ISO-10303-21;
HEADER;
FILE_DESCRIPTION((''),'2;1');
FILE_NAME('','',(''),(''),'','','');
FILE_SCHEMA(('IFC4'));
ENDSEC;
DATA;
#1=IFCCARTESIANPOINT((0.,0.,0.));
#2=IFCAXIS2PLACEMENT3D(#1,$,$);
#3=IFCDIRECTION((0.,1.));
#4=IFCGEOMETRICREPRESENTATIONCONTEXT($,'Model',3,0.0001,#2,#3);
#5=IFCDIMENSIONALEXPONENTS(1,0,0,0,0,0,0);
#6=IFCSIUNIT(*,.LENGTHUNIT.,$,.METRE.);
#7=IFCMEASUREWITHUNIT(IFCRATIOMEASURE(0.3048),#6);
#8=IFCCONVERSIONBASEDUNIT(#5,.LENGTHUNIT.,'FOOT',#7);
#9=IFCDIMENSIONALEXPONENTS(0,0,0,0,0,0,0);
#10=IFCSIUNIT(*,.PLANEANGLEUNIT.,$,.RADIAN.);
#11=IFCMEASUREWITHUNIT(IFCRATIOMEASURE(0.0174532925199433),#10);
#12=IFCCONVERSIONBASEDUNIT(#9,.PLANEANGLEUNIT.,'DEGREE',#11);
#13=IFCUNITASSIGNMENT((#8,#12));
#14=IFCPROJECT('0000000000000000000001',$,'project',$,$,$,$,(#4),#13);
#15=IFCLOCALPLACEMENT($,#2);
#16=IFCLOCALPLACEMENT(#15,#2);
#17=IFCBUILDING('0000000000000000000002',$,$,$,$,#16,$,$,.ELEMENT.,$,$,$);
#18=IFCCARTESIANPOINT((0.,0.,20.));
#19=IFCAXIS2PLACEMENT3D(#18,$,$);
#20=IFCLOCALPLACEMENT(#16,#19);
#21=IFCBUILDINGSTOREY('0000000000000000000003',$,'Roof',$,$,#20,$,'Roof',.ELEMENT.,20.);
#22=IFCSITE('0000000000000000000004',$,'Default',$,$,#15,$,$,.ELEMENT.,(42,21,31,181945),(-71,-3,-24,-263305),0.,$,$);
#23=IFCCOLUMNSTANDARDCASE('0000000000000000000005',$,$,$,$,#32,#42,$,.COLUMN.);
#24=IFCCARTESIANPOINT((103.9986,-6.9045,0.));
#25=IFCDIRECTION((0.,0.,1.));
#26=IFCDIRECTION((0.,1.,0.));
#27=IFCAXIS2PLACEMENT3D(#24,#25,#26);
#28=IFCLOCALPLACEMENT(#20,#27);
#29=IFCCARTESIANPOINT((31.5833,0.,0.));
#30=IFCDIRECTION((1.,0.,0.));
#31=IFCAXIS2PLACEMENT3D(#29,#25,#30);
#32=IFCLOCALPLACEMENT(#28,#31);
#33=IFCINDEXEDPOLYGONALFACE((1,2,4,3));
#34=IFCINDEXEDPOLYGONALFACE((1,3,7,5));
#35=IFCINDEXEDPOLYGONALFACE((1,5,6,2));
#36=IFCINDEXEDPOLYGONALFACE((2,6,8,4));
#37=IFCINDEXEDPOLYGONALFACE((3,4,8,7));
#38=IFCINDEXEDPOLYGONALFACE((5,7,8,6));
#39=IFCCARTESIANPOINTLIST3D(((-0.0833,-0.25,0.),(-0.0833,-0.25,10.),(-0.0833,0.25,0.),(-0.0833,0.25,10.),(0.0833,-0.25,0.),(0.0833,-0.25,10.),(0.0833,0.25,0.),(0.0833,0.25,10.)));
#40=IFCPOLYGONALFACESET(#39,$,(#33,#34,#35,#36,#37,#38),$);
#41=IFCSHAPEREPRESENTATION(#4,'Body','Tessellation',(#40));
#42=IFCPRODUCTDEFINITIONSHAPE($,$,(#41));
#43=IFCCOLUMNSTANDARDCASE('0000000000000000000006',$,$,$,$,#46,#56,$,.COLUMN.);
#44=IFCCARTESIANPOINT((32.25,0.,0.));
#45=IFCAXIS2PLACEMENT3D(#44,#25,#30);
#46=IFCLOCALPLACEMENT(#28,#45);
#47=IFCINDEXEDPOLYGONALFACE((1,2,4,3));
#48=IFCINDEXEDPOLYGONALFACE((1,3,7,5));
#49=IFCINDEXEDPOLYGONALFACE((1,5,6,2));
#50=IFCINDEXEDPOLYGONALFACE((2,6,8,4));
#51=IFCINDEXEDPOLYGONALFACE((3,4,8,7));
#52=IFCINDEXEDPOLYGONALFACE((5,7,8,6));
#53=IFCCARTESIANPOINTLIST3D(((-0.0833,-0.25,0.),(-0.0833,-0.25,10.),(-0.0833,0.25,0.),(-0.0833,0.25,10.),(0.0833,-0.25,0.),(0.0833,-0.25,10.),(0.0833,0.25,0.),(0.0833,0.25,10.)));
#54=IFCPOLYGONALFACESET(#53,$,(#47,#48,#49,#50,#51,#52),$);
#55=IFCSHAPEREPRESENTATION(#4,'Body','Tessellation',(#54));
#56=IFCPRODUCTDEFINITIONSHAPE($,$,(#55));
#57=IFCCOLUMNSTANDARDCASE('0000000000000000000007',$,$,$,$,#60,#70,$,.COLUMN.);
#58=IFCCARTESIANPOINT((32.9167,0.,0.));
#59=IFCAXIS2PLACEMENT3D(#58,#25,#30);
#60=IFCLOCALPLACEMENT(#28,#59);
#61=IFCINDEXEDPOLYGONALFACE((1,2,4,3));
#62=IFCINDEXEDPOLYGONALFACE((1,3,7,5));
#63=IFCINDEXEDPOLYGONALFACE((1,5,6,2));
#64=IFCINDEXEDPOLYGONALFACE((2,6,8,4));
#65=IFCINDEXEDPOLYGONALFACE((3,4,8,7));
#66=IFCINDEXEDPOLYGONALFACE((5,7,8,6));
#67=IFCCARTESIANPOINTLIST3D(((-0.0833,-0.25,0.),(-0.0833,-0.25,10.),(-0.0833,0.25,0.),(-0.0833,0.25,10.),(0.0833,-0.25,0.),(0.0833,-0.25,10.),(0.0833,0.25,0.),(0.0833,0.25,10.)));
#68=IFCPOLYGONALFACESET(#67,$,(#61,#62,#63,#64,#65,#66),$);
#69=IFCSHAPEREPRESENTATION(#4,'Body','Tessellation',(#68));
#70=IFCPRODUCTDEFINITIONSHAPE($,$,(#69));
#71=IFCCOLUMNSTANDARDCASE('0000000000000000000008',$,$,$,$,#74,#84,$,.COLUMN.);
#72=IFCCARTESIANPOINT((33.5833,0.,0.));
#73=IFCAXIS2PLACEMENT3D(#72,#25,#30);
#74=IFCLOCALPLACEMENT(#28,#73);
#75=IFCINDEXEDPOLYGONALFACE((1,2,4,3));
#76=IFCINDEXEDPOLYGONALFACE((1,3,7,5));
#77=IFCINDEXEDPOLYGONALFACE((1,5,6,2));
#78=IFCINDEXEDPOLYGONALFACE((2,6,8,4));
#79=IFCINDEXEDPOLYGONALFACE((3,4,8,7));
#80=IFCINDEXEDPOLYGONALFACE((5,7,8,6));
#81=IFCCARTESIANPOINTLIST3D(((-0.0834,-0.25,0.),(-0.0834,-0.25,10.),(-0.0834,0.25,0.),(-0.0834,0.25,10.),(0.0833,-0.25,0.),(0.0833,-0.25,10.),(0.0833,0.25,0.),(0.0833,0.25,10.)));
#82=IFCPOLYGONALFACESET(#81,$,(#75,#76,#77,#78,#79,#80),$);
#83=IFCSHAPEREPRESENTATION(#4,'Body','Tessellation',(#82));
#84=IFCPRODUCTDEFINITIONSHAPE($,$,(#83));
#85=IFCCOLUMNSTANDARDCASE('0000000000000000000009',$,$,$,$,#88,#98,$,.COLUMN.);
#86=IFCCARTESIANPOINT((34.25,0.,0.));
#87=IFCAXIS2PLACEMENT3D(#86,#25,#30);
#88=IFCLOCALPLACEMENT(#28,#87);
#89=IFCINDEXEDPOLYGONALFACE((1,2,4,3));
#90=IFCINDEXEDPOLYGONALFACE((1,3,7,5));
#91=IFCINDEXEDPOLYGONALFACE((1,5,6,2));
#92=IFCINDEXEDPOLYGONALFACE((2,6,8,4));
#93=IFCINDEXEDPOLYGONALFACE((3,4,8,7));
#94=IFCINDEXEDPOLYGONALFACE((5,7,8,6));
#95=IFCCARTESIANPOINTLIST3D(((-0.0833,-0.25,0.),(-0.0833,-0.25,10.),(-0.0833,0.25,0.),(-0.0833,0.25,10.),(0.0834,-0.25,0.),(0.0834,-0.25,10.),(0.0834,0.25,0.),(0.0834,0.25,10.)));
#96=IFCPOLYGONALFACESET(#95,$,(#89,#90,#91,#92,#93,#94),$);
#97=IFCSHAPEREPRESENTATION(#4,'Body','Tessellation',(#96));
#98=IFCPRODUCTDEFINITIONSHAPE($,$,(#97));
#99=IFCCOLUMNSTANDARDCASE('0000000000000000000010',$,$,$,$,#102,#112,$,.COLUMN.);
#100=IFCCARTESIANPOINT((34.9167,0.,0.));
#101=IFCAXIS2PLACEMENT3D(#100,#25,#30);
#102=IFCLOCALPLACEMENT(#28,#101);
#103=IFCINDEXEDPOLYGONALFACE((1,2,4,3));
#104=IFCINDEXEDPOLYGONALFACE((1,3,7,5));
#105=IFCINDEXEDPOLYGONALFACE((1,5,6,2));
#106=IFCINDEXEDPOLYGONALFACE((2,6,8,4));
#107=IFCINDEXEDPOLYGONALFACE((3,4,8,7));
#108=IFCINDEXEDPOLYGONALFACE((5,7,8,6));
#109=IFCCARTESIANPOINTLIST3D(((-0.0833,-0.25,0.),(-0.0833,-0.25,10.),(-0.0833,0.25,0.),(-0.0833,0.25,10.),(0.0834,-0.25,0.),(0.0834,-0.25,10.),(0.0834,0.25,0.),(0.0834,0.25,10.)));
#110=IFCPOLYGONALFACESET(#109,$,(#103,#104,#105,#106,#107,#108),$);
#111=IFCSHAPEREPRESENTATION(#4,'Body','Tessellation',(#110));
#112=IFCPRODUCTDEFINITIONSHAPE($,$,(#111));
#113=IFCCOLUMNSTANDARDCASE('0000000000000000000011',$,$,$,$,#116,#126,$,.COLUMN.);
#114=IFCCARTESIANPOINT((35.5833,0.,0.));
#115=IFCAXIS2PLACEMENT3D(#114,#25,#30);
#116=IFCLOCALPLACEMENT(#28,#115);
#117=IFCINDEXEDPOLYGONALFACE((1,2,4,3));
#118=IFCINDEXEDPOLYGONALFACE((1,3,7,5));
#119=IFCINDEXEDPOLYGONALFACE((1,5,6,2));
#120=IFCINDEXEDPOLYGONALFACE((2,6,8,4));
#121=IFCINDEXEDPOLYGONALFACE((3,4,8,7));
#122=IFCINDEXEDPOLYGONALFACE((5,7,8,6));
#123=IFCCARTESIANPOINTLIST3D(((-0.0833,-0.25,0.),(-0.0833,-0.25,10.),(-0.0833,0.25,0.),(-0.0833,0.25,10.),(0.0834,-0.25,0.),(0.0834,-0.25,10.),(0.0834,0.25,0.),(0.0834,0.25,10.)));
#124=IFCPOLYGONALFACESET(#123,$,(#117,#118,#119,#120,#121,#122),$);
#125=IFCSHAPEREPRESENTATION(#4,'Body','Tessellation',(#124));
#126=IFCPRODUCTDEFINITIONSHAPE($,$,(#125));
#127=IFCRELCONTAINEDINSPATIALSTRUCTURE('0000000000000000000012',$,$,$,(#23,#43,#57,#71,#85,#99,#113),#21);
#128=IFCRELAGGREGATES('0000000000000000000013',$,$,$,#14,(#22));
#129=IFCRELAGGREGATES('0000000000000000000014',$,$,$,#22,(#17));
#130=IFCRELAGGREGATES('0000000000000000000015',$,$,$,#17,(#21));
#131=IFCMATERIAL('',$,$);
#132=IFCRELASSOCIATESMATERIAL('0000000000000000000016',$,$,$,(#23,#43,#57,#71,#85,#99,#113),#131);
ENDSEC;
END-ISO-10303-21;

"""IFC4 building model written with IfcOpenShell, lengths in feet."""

from ifc_helpers import new_model, entity, si_unit, converted_unit, direction, frame, origin, place, context, project, spatial, rectangle, extrude, material, element, save


model = new_model("IFC4")

# Units and contexts
model_context = context("Model", 3, precision=0.0001, world=origin(), true_north=direction((0.0, 1.0)))
ifc_project = project(units=[converted_unit("LENGTHUNIT", "FOOT", entity("IfcRatioMeasure", 0.3048), si_unit("LENGTHUNIT", "METRE"), dimensions=[1, 0, 0, 0, 0, 0, 0]), converted_unit("PLANEANGLEUNIT", "DEGREE", entity("IfcRatioMeasure", 0.0174532925199433), si_unit("PLANEANGLEUNIT", "RADIAN"), dimensions=[0, 0, 0, 0, 0, 0, 0])], contexts=[model_context])

# Site, building, storey
site_placement = place(None, origin())
site = spatial("IfcSite", under=ifc_project, at=site_placement, Name="Default", CompositionType="ELEMENT", RefLatitude=(42, 21, 31, 181945), RefLongitude=(-71, -3, -24, -263305), RefElevation=0.0)
building_placement = place(site_placement, origin())
building = spatial("IfcBuilding", under=site, at=building_placement, CompositionType="ELEMENT")
storey_placement = place(building_placement, frame((0.0, 0.0, 20.0)))
storey = spatial("IfcBuildingStorey", under=building, at=storey_placement, Name="Roof", LongName="Roof", CompositionType="ELEMENT", Elevation=20.0)

# Columns
ifc_material_1 = material(Name="")
placement_1 = place(storey_placement, frame((103.9986, -6.9045, 0.0), z_axis=(0.0, 0.0, 1.0), x_axis=(0.0, 1.0, 0.0)))
for number, where, z_axis, x_axis in (
    (1, (31.5833, 0.0, 0.0), (0.0, 0.0, 1.0), (1.0, 0.0, 0.0)),
    (2, (32.25, 0.0, 0.0), (0.0, 0.0, 1.0), (1.0, 0.0, 0.0)),
    (3, (32.9167, 0.0, 0.0), (0.0, 0.0, 1.0), (1.0, 0.0, 0.0)),
    (4, (33.5833, 0.0, 0.0), (0.0, 0.0, 1.0), (1.0, 0.0, 0.0)),
    (5, (34.25, 0.0, 0.0), (0.0, 0.0, 1.0), (1.0, 0.0, 0.0)),
    (6, (34.9167, 0.0, 0.0), (0.0, 0.0, 1.0), (1.0, 0.0, 0.0)),
    (7, (35.5833, 0.0, 0.0), (0.0, 0.0, 1.0), (1.0, 0.0, 0.0)),
):
    element("IfcColumnStandardCase", number, at=place(placement_1, frame(where, z_axis=z_axis, x_axis=x_axis)), inside=storey, material=ifc_material_1, PredefinedType="COLUMN", context=model_context, shape_type="SweptSolid", body=[
        extrude(rectangle(XDim=0.1667, YDim=0.5), origin(), (0.0, 0.0, 1.0), 10.0),
    ])

save(model, "model.ifc")
